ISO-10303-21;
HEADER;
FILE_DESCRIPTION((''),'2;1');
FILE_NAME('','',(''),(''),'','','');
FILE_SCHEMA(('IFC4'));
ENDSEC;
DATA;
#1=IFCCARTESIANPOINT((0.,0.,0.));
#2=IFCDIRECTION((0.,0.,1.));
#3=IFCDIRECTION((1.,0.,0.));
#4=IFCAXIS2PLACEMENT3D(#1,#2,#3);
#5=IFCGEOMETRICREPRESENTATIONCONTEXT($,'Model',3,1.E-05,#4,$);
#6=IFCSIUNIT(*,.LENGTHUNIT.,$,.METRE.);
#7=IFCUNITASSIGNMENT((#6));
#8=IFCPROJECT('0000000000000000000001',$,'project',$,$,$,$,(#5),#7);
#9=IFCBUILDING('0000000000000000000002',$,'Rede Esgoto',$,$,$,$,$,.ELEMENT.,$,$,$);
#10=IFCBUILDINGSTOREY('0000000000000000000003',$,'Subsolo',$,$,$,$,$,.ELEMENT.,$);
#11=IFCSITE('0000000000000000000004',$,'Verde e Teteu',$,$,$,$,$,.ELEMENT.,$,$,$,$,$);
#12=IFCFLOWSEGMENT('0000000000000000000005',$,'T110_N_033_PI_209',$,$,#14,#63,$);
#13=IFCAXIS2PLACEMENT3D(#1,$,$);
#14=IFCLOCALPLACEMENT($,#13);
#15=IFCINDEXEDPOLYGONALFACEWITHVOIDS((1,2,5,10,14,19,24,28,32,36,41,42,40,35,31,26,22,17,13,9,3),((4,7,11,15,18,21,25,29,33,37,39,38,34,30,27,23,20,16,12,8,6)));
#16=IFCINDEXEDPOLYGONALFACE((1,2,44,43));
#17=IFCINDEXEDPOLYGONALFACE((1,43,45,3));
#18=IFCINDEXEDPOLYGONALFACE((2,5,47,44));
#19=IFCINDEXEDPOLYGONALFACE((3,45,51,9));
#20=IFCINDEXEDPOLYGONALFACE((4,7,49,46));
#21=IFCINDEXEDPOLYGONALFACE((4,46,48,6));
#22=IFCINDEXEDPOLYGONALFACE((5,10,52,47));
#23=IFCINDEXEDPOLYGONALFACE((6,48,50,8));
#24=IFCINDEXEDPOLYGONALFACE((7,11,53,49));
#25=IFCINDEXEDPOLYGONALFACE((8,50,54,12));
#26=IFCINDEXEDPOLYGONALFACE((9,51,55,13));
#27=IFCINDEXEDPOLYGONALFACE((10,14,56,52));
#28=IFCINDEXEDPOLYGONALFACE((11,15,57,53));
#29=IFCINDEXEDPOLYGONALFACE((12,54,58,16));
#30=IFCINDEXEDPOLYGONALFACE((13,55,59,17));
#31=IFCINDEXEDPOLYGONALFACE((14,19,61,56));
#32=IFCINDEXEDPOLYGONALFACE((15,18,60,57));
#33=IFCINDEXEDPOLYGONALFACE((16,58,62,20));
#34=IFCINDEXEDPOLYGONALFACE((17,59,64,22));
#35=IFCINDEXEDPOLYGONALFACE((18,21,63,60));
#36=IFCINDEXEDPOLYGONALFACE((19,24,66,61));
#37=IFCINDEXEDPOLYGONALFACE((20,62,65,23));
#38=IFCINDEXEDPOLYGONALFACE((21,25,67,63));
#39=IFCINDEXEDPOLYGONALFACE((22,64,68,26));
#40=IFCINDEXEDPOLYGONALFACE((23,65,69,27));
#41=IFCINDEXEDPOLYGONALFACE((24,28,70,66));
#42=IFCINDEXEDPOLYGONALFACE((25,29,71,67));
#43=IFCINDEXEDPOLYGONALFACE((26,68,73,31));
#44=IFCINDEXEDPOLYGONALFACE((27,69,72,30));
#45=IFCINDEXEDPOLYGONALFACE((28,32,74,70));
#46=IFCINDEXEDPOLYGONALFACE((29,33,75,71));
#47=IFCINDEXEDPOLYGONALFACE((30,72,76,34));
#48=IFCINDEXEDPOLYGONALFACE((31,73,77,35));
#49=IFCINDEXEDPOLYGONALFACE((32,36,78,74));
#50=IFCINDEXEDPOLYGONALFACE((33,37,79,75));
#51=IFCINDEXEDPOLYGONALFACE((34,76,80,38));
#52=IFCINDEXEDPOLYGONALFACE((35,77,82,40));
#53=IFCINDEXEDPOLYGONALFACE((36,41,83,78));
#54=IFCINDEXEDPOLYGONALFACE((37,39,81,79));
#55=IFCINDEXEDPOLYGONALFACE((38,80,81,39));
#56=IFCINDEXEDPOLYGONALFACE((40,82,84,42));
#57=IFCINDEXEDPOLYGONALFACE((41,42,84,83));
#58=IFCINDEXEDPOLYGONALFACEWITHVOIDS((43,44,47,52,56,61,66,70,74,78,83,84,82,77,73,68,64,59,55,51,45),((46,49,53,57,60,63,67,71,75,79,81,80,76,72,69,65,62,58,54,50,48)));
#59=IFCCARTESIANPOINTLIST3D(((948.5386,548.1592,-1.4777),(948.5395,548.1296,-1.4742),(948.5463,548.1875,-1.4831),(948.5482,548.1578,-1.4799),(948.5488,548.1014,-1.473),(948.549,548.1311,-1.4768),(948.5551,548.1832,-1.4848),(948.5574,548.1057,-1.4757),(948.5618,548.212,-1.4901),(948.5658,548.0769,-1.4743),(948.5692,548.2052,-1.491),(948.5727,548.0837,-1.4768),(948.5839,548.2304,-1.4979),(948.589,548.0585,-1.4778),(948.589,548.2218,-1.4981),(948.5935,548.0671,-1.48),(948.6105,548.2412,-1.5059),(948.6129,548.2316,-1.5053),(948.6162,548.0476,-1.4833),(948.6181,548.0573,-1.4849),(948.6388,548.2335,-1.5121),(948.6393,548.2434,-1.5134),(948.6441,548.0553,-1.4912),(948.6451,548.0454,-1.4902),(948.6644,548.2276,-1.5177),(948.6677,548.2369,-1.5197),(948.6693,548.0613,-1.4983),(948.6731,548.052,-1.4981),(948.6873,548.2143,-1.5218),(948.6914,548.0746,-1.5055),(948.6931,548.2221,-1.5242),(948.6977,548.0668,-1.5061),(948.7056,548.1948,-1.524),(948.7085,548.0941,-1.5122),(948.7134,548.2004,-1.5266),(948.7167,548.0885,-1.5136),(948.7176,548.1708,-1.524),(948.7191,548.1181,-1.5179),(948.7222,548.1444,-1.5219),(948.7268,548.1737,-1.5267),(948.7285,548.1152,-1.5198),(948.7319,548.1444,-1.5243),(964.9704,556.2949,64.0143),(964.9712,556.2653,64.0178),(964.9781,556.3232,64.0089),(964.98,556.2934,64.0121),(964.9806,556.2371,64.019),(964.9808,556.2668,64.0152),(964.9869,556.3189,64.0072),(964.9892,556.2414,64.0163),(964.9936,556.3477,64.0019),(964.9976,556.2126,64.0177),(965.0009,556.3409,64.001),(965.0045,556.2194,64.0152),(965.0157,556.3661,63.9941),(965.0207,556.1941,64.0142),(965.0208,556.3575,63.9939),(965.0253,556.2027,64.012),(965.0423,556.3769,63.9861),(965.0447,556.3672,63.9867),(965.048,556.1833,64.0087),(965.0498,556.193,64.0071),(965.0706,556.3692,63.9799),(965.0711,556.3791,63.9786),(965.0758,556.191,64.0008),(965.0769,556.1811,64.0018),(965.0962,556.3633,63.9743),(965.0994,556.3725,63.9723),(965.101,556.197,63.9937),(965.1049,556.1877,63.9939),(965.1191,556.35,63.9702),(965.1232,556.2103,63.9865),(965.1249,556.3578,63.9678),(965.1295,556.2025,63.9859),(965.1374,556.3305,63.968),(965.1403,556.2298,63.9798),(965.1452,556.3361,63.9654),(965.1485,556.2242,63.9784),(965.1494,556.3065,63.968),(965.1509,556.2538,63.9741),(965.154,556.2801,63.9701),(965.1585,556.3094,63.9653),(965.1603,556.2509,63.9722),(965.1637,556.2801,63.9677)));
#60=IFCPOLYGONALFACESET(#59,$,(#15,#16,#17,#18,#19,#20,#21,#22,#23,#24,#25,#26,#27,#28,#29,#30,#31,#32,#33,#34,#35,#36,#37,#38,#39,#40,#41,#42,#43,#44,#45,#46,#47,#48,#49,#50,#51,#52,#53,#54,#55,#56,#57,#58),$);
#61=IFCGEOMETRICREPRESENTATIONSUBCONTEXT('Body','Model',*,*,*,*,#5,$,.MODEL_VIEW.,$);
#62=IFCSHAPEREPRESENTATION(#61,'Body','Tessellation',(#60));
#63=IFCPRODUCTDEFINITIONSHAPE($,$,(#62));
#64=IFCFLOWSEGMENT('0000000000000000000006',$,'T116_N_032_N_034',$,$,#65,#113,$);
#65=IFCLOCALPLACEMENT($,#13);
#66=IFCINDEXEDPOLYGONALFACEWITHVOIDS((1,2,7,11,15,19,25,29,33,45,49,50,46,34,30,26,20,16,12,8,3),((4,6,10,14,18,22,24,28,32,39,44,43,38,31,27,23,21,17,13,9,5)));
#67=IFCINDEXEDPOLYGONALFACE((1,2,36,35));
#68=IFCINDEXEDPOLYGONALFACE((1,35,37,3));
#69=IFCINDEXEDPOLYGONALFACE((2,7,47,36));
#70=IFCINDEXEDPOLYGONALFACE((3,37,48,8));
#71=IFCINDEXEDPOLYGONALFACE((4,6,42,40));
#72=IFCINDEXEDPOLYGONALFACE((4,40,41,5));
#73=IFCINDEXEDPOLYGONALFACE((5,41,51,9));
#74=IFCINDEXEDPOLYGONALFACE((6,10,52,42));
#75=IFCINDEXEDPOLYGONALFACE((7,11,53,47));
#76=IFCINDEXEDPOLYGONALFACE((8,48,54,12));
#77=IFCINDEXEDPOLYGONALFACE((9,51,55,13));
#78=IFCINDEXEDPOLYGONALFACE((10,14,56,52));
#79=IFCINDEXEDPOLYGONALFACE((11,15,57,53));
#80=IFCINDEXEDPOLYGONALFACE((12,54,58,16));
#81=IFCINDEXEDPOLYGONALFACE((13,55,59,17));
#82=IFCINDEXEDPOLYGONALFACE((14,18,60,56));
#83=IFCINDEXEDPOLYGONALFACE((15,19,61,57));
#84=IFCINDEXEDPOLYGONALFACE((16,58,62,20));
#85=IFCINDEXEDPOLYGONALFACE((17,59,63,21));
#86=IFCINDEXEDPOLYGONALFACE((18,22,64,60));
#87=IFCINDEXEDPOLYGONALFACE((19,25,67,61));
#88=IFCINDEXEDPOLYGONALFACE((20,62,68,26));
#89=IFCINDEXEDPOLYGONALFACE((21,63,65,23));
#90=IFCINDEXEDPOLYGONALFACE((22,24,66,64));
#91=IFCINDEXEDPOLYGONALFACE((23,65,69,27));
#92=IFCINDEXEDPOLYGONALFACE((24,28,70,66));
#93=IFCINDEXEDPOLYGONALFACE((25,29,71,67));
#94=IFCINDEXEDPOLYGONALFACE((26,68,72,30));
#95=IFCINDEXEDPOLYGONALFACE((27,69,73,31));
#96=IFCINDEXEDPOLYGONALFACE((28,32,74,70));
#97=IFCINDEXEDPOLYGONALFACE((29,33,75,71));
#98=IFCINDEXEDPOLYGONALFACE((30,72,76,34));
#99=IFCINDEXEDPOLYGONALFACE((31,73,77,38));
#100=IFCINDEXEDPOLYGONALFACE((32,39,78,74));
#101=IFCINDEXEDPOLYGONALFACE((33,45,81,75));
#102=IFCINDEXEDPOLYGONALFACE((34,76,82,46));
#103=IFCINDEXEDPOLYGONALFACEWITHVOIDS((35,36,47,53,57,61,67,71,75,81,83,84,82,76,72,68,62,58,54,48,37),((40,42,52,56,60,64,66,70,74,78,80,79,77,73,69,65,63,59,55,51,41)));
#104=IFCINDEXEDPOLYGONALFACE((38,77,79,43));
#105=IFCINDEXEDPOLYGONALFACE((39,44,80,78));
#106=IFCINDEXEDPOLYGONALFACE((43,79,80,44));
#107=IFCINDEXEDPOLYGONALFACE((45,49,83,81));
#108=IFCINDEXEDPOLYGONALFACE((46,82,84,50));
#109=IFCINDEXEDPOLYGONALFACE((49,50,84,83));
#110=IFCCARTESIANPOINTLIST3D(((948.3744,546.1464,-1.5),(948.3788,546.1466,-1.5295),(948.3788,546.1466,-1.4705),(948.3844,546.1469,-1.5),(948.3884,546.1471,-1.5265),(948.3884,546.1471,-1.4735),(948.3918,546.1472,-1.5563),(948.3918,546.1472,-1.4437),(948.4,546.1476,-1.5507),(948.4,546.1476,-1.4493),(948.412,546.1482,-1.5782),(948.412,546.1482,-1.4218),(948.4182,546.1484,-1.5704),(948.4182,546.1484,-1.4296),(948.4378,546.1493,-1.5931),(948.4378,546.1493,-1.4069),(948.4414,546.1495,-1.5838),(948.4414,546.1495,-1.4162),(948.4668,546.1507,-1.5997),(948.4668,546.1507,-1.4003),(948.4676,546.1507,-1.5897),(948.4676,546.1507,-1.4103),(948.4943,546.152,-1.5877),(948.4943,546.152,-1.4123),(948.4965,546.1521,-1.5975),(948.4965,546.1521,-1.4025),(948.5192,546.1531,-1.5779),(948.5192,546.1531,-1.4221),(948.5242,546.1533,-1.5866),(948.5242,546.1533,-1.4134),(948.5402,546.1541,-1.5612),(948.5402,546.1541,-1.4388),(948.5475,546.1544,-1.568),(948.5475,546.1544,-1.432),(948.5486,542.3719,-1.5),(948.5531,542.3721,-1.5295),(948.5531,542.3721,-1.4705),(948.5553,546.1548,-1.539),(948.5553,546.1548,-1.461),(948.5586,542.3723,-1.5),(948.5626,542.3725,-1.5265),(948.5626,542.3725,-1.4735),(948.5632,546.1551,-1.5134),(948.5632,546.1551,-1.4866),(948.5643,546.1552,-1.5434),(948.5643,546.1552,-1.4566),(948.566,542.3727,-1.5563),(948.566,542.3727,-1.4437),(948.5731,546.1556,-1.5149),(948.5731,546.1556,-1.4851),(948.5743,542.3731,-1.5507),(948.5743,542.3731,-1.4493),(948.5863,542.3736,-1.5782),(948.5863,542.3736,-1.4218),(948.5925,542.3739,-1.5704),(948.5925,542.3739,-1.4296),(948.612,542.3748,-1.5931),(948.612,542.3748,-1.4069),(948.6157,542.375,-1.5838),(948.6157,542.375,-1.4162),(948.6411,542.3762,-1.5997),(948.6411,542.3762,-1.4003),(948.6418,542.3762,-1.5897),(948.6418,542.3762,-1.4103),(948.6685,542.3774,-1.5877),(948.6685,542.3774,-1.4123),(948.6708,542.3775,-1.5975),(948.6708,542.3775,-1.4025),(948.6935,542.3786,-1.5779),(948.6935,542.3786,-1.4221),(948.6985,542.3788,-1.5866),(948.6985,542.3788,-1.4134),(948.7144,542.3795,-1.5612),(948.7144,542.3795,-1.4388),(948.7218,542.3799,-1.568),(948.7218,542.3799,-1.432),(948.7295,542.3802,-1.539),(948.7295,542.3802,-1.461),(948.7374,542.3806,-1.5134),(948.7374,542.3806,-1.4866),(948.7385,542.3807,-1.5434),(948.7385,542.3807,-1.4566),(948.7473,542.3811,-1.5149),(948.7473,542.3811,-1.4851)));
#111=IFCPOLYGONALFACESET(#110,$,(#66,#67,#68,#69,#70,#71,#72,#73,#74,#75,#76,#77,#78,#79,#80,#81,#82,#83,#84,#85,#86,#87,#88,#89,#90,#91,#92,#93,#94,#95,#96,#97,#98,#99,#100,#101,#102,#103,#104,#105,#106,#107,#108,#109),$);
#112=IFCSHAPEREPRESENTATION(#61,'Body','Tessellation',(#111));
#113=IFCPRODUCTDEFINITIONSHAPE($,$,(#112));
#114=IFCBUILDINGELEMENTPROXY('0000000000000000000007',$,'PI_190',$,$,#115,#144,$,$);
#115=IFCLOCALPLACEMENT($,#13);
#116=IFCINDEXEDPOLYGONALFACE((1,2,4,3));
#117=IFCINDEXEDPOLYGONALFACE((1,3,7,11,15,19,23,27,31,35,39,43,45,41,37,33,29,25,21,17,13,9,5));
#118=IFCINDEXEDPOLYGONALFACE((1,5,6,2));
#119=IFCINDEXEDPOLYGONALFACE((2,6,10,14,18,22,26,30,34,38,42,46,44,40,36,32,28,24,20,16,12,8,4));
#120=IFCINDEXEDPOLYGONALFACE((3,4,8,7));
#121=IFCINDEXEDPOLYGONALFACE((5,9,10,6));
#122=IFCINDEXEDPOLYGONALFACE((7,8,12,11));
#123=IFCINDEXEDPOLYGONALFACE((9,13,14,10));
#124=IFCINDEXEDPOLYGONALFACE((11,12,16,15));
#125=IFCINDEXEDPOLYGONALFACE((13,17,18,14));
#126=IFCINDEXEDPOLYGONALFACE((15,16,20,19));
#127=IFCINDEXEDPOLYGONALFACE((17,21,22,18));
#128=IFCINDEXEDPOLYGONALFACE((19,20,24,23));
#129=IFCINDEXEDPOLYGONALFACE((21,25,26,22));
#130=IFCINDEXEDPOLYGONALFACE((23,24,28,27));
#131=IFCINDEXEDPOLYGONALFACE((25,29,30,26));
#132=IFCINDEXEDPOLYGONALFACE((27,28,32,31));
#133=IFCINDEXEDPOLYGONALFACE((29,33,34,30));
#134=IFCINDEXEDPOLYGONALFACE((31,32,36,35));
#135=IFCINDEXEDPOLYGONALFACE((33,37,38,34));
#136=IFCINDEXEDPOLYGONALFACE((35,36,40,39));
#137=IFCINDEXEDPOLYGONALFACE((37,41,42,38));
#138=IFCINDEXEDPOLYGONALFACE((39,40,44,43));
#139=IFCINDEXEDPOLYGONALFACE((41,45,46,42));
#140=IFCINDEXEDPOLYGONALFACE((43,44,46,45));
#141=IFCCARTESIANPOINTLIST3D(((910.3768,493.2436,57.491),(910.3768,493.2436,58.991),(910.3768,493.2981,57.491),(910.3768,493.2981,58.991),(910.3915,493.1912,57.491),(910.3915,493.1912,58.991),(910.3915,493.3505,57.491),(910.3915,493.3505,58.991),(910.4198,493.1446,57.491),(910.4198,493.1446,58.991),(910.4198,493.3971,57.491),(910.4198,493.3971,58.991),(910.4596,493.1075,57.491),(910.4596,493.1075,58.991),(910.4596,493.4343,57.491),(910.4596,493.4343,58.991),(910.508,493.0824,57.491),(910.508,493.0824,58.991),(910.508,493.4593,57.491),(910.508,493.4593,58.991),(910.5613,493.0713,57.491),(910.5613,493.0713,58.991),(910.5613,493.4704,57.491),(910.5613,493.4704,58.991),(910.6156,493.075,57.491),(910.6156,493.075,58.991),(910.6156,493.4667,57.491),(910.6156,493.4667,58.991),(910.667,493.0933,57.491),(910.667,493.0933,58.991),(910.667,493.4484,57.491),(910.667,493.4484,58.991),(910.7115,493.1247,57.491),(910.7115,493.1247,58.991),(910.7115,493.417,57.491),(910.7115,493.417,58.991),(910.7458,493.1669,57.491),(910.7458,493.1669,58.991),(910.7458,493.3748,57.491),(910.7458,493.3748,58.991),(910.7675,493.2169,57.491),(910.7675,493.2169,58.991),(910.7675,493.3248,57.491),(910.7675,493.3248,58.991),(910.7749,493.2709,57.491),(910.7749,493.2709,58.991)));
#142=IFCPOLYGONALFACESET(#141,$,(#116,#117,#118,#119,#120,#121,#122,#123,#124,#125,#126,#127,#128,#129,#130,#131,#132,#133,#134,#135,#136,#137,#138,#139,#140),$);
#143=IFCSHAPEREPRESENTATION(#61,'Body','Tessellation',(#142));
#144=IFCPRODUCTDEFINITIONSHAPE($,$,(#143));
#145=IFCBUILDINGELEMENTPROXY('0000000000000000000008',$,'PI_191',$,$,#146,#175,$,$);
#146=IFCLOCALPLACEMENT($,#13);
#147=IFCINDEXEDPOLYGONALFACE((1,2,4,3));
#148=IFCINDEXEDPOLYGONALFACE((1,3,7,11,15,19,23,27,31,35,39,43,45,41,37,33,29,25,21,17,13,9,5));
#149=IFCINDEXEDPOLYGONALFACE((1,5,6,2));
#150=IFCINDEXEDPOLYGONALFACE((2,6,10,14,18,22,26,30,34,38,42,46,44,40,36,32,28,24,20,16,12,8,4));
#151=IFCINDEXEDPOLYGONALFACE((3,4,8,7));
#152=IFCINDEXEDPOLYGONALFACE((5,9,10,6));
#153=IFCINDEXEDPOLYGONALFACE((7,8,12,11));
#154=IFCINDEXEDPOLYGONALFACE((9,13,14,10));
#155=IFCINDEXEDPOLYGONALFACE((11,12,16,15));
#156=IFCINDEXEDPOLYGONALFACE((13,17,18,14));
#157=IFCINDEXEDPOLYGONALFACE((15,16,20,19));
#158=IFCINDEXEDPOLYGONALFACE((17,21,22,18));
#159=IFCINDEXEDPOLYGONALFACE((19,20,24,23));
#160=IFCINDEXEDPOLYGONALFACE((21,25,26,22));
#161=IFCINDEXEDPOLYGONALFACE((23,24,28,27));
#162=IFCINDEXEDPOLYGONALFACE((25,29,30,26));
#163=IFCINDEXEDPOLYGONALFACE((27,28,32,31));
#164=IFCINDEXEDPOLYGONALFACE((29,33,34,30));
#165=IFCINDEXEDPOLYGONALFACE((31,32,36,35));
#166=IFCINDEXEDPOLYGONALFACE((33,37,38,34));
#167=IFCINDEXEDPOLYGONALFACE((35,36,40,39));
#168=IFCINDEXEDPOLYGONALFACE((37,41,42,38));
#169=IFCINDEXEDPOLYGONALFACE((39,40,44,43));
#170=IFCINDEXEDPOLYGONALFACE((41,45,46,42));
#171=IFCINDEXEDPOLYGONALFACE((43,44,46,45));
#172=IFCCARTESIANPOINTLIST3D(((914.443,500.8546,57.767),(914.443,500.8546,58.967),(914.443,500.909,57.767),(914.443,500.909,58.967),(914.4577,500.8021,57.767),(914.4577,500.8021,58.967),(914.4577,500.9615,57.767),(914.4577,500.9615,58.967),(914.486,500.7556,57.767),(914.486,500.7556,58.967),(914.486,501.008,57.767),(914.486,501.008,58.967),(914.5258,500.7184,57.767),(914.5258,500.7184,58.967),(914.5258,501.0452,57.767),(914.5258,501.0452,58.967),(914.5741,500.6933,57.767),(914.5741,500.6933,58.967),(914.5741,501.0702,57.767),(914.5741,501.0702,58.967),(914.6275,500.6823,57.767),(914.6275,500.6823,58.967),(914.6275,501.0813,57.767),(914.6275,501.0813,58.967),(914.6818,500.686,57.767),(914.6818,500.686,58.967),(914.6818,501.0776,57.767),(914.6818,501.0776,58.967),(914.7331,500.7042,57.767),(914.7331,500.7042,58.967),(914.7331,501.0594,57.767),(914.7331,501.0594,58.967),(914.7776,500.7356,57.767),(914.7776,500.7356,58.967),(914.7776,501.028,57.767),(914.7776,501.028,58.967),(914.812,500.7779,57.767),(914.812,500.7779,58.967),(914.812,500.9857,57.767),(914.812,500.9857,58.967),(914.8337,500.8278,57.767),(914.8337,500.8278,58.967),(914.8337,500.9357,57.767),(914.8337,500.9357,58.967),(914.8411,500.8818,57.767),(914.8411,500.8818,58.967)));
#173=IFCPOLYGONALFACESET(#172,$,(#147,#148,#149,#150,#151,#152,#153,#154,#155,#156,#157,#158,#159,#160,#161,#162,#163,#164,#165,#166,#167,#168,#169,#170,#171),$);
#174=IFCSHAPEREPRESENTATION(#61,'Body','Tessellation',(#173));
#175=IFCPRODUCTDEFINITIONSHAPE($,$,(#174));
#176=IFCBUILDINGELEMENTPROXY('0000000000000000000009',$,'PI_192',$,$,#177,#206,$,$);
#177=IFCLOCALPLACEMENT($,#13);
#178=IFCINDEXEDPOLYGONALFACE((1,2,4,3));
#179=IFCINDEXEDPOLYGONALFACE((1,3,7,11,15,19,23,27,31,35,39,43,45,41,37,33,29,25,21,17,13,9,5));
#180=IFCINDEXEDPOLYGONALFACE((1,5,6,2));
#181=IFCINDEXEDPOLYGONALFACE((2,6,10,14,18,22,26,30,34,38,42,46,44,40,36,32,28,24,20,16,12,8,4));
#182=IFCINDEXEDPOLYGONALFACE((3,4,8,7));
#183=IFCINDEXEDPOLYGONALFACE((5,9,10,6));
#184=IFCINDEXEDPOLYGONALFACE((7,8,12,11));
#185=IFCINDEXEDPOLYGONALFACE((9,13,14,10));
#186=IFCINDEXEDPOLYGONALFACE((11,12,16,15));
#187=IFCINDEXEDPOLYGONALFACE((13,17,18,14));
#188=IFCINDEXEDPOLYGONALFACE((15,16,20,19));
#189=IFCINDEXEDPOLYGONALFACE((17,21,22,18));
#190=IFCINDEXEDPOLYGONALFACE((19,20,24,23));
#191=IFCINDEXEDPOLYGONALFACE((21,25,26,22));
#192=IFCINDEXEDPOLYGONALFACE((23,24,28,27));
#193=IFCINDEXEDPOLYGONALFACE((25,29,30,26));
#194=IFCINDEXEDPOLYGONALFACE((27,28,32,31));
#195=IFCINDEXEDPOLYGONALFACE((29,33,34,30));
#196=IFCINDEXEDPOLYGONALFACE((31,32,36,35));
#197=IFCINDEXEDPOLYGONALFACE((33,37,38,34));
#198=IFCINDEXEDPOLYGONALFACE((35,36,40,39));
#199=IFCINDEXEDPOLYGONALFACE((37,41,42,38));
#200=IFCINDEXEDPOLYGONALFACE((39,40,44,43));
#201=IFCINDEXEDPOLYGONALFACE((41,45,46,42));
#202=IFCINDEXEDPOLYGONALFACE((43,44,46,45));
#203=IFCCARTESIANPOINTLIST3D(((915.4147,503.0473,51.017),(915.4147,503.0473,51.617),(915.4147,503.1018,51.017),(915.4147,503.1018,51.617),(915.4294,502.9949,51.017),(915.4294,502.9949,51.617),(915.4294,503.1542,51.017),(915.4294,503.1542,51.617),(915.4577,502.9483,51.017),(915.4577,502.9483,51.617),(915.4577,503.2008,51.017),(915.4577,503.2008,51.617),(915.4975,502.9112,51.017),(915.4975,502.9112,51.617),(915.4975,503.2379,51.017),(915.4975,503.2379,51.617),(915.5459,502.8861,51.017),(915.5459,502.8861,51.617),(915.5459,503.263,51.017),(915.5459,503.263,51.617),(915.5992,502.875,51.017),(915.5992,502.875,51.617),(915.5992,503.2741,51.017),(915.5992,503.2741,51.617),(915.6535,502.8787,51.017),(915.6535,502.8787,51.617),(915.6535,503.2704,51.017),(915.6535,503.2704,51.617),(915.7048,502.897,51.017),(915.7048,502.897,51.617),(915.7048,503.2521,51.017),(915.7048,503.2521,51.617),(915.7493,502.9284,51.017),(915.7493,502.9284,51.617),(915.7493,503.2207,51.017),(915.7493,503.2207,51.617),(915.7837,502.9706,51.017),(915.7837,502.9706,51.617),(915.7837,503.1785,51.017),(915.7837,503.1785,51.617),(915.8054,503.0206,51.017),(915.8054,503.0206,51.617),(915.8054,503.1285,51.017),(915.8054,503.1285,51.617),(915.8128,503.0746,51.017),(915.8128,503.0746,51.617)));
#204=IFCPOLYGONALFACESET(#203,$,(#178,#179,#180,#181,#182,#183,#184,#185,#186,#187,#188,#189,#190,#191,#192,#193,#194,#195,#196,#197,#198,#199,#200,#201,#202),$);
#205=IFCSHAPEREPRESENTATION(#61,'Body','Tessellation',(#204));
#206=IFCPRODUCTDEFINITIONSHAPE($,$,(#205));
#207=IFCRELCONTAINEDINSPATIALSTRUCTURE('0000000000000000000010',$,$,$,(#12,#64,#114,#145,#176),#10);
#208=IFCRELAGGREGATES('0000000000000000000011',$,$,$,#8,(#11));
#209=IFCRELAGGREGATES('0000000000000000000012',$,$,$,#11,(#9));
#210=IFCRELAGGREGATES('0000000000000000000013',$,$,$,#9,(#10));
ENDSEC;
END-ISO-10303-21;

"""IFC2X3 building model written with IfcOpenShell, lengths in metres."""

from ifc_helpers import new_model, entity, si_unit, frame, origin_with_axes, origin_2d, place, context, subcontext, project, spatial, circle, extrude, element, save


model = new_model("IFC2X3")

# Units and contexts
model_context = context("Model", 3, precision=1e-05, world=origin_with_axes())
body_context = subcontext(model_context, "Body", "Model", "MODEL_VIEW")
ifc_project = project(units=[si_unit("LENGTHUNIT", "METRE")], contexts=[model_context])

# Site, building, storey
site = spatial("IfcSite", under=ifc_project, Name="Verde e Teteu", CompositionType="ELEMENT")
building = spatial("IfcBuilding", under=site, Name="Rede Esgoto", CompositionType="ELEMENT")
storey = spatial("IfcBuildingStorey", under=building, Name="Subsolo", CompositionType="ELEMENT")

# Flow segments
flow_segment_1_placement = place(None, frame((948.6349, 548.1444, -1.5), z_axis=(0.0, 0.0, 1.0), x_axis=(1.0, 0.0, 0.0)))
element("IfcFlowSegment", 1, at=flow_segment_1_placement, inside=storey, Name="T110_N_033_PI_209", context=body_context, shape_type="SweptSolid", body=[
    entity("IfcSweptDiskSolid", entity("IfcPolyline", [entity("IfcCartesianPoint", [0.0, 0.0, 0.0]), entity("IfcCartesianPoint", [16.4318, 8.1357, 65.492])]), 0.1, 0.09),
])
flow_segment_2_placement = place(None, frame((948.4743, 546.151, -1.5), z_axis=(0.0, 0.0, 1.0), x_axis=(1.0, 0.0, 0.0)))
element("IfcFlowSegment", 2, at=flow_segment_2_placement, inside=storey, Name="T116_N_032_N_034", context=body_context, shape_type="SweptSolid", body=[
    entity("IfcSweptDiskSolid", entity("IfcPolyline", [entity("IfcCartesianPoint", [0.0, 0.0, 0.0]), entity("IfcCartesianPoint", [0.1742, -3.7745, 0.0])]), 0.1, 0.09),
])

# Building element proxies
proxy_1_placement = place(None, frame((910.5749, 493.2709, 57.491), z_axis=(0.0, 0.0, 1.0), x_axis=(1.0, 0.0, 0.0)))
element("IfcBuildingElementProxy", 3, at=proxy_1_placement, inside=storey, Name="PI_190", context=body_context, shape_type="SweptSolid", body=[
    extrude(circle(Radius=0.2, at=origin_2d()), origin_with_axes(), (0.0, 0.0, 1.0), 1.5),
])
proxy_2_placement = place(None, frame((914.6411, 500.8818, 57.767), z_axis=(0.0, 0.0, 1.0), x_axis=(1.0, 0.0, 0.0)))
element("IfcBuildingElementProxy", 4, at=proxy_2_placement, inside=storey, Name="PI_191", context=body_context, shape_type="SweptSolid", body=[
    extrude(circle(Radius=0.2, at=origin_2d()), origin_with_axes(), (0.0, 0.0, 1.0), 1.2),
])
proxy_3_placement = place(None, frame((915.6128, 503.0746, 51.017), z_axis=(0.0, 0.0, 1.0), x_axis=(1.0, 0.0, 0.0)))
element("IfcBuildingElementProxy", 5, at=proxy_3_placement, inside=storey, Name="PI_192", context=body_context, shape_type="SweptSolid", body=[
    extrude(circle(Radius=0.2, at=origin_2d()), origin_with_axes(), (0.0, 0.0, 1.0), 0.6),
])

save(model, "model.ifc")
